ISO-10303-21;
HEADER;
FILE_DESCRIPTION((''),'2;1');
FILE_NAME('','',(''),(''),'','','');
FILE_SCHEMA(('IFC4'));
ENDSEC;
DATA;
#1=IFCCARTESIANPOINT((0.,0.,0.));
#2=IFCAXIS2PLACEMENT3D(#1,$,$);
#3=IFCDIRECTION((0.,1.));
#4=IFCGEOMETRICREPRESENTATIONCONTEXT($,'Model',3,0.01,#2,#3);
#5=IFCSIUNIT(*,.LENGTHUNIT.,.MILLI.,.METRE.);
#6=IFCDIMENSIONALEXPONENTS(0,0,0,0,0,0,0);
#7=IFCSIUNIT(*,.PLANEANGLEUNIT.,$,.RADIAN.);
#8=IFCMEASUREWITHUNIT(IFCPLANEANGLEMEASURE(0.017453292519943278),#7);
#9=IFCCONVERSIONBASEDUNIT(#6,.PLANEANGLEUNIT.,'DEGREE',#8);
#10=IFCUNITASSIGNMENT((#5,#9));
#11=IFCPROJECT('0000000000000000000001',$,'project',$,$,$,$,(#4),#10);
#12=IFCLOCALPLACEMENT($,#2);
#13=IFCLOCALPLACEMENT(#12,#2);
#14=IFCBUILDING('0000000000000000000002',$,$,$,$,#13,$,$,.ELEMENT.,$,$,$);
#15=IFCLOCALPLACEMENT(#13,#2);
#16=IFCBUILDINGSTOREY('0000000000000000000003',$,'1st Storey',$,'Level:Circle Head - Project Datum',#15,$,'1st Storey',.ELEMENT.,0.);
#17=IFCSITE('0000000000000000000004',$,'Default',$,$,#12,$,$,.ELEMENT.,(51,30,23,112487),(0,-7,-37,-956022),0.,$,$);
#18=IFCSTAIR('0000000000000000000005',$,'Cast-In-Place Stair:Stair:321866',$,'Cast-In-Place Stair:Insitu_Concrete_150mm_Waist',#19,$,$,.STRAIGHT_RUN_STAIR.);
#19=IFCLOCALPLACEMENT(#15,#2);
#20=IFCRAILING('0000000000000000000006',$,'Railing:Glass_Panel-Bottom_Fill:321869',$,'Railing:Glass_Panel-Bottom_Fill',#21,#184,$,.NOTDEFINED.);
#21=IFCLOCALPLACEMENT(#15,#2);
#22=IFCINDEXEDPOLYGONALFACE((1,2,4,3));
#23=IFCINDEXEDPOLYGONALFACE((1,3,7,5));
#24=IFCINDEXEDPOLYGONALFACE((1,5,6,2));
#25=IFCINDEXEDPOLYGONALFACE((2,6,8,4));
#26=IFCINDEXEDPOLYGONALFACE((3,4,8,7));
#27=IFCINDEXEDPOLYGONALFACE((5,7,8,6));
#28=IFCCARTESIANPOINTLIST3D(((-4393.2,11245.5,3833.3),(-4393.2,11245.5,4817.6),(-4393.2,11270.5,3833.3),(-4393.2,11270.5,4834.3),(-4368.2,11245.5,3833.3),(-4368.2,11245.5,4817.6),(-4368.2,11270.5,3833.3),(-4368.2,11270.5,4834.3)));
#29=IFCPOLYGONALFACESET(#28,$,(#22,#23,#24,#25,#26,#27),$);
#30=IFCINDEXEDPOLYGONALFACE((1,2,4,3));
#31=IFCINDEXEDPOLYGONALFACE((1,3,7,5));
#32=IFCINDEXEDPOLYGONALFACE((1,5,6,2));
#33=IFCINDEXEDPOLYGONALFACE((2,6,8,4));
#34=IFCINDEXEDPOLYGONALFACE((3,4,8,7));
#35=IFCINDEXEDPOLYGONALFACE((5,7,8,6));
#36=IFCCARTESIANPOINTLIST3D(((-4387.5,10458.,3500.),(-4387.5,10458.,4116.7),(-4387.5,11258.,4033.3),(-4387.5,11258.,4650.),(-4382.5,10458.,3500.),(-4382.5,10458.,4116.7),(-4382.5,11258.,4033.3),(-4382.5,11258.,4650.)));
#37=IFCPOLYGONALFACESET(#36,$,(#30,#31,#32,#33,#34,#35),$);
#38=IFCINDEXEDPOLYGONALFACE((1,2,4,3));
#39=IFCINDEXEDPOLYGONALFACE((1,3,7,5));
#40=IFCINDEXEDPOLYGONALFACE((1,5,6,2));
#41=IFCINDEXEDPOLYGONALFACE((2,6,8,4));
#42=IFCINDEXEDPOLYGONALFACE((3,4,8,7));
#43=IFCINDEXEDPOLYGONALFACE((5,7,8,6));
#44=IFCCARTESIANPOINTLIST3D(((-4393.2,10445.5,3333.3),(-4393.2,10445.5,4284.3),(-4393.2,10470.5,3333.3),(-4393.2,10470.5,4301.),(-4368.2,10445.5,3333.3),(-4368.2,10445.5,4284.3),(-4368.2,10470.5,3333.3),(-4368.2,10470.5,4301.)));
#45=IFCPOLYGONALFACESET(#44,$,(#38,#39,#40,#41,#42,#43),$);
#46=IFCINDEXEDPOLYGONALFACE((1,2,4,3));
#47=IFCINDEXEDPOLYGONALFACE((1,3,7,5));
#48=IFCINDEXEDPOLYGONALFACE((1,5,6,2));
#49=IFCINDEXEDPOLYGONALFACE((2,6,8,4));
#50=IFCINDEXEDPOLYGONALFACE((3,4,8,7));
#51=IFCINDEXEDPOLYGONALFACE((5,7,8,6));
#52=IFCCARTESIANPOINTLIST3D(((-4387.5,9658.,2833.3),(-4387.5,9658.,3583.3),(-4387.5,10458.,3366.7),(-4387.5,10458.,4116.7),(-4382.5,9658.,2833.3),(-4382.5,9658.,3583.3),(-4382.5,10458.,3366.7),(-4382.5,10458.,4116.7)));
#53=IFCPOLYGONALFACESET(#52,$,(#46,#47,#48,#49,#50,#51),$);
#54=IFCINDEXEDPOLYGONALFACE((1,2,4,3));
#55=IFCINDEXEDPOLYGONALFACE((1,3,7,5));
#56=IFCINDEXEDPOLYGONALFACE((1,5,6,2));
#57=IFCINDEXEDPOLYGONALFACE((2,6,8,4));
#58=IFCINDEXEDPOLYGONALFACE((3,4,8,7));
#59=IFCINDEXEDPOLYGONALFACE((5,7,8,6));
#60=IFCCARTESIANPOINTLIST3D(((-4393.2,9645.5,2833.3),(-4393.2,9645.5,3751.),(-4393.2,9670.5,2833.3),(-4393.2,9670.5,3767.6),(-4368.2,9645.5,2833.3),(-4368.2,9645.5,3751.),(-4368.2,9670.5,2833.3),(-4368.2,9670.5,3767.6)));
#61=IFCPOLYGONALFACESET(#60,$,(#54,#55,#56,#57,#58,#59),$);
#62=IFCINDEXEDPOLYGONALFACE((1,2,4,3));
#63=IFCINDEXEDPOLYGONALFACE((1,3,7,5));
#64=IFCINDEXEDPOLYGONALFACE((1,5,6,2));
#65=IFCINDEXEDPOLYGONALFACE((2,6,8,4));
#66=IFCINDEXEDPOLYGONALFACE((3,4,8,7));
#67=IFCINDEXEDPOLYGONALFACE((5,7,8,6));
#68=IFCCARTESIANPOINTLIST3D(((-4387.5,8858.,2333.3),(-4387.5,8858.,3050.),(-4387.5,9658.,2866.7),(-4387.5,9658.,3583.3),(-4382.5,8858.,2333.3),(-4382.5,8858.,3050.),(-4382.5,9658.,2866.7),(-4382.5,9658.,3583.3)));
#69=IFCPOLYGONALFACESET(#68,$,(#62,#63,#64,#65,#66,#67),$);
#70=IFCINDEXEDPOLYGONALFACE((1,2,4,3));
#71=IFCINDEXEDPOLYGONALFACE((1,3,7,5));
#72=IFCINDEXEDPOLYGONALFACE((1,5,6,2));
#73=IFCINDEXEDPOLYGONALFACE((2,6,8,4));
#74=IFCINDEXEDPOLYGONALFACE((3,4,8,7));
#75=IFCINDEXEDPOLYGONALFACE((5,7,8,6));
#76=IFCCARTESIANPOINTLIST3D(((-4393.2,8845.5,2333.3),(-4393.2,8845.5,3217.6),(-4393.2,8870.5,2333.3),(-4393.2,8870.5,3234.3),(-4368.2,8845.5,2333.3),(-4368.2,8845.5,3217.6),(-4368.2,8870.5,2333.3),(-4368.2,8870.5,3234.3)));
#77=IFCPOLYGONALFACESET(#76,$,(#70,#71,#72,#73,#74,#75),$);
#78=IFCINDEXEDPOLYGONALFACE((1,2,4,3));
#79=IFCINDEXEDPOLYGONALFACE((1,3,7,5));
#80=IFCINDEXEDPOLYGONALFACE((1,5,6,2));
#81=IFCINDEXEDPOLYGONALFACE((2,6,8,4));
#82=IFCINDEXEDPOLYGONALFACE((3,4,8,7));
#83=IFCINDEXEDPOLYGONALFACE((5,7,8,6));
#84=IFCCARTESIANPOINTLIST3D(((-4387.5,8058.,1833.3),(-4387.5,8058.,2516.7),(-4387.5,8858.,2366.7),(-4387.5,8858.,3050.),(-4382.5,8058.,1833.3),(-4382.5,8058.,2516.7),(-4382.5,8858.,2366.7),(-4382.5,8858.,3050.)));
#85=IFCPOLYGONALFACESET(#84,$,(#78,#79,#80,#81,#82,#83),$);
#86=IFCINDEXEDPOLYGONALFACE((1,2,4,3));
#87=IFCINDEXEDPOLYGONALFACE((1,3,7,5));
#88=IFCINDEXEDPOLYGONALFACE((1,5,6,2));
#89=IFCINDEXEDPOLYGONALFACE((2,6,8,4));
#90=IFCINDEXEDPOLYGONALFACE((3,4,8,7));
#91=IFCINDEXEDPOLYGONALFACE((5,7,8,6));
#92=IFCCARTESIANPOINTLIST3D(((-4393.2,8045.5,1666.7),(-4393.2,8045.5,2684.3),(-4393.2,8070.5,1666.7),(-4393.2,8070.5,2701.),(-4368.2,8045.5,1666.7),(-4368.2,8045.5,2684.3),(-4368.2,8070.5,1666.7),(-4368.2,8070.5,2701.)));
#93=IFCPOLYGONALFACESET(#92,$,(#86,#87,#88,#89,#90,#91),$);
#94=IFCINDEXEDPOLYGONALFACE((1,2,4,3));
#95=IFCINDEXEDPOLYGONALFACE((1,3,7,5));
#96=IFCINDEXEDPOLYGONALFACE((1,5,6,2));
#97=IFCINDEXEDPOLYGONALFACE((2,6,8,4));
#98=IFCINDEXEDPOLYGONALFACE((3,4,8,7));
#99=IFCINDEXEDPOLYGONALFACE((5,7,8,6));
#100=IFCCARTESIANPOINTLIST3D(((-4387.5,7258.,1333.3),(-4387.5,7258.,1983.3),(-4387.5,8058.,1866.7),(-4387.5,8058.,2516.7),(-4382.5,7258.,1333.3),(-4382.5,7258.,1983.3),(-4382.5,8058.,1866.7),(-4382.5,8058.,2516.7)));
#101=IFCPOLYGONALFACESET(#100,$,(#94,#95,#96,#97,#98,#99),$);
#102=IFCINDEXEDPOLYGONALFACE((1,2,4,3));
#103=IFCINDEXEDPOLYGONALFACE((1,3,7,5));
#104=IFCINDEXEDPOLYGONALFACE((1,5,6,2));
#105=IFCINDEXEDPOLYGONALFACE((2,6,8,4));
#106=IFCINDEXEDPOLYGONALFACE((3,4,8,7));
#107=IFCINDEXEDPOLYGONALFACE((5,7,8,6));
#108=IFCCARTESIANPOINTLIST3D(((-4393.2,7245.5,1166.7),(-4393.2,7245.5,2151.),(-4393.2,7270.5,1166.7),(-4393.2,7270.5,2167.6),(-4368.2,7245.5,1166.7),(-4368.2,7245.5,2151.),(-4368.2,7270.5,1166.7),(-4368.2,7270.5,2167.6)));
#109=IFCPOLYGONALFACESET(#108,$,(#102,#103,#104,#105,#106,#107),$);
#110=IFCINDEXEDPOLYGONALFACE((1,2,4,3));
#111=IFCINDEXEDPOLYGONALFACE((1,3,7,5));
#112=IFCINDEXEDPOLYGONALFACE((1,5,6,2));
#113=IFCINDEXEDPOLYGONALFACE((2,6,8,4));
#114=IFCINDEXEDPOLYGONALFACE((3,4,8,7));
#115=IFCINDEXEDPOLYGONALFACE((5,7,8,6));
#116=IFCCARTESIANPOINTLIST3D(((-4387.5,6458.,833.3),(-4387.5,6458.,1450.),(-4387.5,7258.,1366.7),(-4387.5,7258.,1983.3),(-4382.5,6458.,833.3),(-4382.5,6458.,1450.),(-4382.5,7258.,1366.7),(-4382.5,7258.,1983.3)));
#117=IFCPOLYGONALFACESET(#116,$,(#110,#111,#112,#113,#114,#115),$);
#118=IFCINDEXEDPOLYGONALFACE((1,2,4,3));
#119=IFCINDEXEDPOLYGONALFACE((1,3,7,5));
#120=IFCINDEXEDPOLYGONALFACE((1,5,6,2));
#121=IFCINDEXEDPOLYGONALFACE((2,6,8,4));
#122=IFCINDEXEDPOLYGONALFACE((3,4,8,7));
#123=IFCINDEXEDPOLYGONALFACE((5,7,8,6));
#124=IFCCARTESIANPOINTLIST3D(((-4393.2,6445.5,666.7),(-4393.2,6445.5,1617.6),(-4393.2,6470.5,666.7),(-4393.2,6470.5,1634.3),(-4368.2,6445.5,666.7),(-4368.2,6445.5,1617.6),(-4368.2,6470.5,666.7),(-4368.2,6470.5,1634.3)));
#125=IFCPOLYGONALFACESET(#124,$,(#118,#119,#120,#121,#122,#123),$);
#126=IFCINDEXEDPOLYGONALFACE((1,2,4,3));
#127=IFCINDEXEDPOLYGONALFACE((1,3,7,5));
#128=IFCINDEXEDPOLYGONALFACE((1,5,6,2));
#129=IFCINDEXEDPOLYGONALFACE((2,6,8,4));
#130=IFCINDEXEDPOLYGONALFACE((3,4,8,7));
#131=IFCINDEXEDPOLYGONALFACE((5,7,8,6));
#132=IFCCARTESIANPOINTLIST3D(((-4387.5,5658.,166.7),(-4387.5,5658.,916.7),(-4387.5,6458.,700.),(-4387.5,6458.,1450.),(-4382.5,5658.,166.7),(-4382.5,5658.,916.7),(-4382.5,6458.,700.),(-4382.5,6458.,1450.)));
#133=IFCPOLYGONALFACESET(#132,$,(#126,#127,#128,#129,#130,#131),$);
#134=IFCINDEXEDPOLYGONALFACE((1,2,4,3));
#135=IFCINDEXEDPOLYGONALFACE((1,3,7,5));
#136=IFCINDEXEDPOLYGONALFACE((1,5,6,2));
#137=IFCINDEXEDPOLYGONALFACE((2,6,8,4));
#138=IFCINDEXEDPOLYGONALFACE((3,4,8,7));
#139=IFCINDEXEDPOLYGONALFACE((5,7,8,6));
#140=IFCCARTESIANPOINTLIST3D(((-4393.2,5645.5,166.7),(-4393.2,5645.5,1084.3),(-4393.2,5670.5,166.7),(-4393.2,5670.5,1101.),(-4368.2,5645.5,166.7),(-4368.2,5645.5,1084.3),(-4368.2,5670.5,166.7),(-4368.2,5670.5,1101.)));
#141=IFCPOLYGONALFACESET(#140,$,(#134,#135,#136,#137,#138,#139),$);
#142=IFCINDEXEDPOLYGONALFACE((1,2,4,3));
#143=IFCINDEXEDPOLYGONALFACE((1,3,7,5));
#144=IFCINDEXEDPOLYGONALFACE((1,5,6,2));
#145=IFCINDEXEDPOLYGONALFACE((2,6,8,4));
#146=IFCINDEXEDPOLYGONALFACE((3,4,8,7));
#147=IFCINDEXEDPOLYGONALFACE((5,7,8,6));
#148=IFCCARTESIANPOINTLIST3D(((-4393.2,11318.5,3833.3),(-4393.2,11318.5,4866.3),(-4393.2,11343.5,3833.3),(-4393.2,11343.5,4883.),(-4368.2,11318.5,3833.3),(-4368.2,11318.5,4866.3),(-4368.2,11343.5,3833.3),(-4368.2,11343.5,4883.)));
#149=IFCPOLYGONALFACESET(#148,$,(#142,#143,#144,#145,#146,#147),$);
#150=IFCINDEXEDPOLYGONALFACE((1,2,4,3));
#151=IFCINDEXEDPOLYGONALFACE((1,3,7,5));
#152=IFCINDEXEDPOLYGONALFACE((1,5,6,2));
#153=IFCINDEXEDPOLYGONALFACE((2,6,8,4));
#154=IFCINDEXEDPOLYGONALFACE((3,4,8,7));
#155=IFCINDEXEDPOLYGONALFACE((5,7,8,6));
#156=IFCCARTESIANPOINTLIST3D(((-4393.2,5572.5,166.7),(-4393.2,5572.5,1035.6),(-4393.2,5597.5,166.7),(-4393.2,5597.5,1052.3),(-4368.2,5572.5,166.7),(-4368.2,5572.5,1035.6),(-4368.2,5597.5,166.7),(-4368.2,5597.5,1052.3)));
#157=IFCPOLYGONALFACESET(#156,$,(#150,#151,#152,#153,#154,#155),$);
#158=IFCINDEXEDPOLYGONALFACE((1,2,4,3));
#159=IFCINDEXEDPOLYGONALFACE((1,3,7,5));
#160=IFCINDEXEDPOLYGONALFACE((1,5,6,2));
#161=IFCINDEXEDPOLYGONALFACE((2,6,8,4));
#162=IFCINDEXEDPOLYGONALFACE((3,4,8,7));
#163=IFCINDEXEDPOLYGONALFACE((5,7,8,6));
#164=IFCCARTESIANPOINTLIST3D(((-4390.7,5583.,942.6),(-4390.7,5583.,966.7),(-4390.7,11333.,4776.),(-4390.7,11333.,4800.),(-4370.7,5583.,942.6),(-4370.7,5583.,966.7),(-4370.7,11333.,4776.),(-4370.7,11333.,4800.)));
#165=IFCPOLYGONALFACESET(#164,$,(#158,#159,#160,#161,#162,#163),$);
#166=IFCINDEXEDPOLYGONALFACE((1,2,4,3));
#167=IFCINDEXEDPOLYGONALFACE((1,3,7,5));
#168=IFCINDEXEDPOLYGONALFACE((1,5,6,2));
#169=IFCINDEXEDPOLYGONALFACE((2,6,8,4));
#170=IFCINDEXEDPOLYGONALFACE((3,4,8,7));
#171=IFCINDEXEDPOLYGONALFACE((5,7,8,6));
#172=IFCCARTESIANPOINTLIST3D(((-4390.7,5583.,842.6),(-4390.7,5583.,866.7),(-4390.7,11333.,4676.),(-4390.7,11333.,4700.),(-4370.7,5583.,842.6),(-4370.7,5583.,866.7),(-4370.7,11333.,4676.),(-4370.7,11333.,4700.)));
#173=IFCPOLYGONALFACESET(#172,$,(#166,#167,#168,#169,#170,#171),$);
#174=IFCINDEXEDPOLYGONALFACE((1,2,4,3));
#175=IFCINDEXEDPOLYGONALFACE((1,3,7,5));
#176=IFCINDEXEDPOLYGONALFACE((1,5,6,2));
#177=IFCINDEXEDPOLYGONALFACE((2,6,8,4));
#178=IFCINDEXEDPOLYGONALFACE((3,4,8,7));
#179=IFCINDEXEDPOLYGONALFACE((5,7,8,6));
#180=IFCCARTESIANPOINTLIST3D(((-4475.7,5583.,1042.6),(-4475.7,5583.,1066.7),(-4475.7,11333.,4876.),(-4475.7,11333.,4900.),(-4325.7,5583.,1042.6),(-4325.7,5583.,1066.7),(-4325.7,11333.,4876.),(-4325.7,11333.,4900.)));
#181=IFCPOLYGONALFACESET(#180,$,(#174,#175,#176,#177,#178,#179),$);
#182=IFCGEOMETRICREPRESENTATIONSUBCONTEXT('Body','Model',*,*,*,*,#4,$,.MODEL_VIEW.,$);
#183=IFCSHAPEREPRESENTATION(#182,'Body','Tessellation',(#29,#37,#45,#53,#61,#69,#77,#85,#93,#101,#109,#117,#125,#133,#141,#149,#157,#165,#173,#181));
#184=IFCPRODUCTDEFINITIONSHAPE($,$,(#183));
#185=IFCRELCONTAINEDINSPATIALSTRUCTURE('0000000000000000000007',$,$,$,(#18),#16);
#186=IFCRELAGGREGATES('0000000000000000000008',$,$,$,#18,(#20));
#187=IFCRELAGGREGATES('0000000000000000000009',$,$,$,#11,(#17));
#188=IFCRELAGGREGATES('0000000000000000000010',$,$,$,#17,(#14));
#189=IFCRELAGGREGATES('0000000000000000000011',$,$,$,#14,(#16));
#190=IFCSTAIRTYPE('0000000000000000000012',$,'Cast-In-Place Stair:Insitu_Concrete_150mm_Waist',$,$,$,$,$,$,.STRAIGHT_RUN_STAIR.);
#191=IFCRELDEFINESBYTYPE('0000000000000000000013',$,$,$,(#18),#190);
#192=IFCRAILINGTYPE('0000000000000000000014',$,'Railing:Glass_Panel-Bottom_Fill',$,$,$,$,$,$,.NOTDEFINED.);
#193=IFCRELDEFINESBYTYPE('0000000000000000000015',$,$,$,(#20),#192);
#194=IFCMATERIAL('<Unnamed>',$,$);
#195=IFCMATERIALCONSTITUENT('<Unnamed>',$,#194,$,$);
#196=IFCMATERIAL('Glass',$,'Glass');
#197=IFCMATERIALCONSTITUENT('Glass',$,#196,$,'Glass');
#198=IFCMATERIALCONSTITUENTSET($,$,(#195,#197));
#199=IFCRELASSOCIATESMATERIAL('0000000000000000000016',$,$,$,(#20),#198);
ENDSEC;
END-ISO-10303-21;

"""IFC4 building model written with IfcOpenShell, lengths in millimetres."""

from ifc_helpers import new_model, entity, si_unit, converted_unit, direction, frame, origin, place, context, subcontext, project, spatial, indexed_curve, outline, extrude, material, constituent, constituent_set, type_object, element, aggregate, save


model = new_model("IFC4")

# Units and contexts
model_context = context("Model", 3, precision=0.01, world=origin(), true_north=direction((0.0, 1.0)))
body_context = subcontext(model_context, "Body", "Model", "MODEL_VIEW")
ifc_project = project(units=[si_unit("LENGTHUNIT", "METRE", prefix="MILLI"), converted_unit("PLANEANGLEUNIT", "DEGREE", entity("IfcPlaneAngleMeasure", 0.017453292519943278), si_unit("PLANEANGLEUNIT", "RADIAN"), dimensions=[0, 0, 0, 0, 0, 0, 0])], contexts=[model_context])

# Site, building, storey
site_placement = place(None, origin())
site = spatial("IfcSite", under=ifc_project, at=site_placement, Name="Default", CompositionType="ELEMENT", RefLatitude=(51, 30, 23, 112487), RefLongitude=(0, -7, -37, -956022), RefElevation=0.0)
building_placement = place(site_placement, origin())
building = spatial("IfcBuilding", under=site, at=building_placement, CompositionType="ELEMENT")
storey_placement = place(building_placement, origin())
storey = spatial("IfcBuildingStorey", under=building, at=storey_placement, Name="1st Storey", ObjectType="Level:Circle Head - Project Datum", LongName="1st Storey", CompositionType="ELEMENT", Elevation=0.0)

# Shared definitions
ifc_material_1 = material(Name="<Unnamed>")

# Shared definitions
stair_type_1 = type_object("IfcStairType", Name="Cast-In-Place Stair:Insitu_Concrete_150mm_Waist", PredefinedType="STRAIGHT_RUN_STAIR")

# Stair, railing
ifc_material_2 = material(Name="Glass", Category="Glass")
railing_type_1 = type_object("IfcRailingType", Name="Railing:Glass_Panel-Bottom_Fill", PredefinedType="NOTDEFINED")
stair_1_placement = place(storey_placement, origin())
stair_1 = element("IfcStair", 1, at=stair_1_placement, inside=storey, type_object=stair_type_1, Name="Cast-In-Place Stair:Stair:321866", ObjectType="Cast-In-Place Stair:Insitu_Concrete_150mm_Waist", PredefinedType="STRAIGHT_RUN_STAIR")
ifc_constituent_1 = constituent(ifc_material_1, Name="<Unnamed>")
ifc_constituent_2 = constituent(ifc_material_2, Name="Glass", Category="Glass")
ifc_constituent_set_1 = constituent_set(constituents=[ifc_constituent_1, ifc_constituent_2])
railing_1_placement = place(stair_1_placement, frame((-4475.7, 5572.5, 166.7)))
railing_1 = element("IfcRailing", 2, at=railing_1_placement, type_object=railing_type_1, material=ifc_constituent_set_1, Name="Railing:Glass_Panel-Bottom_Fill:321869", ObjectType="Railing:Glass_Panel-Bottom_Fill", PredefinedType="NOTDEFINED", context=body_context, shape_type="SweptSolid", body=[
    extrude(outline(indexed_curve([(-488.0, -12.5), (496.3, -12.5), (496.3, 12.5), (-504.6, 12.5), (-488.0, -12.5)], self_intersect=False)), frame((82.5, 5685.5, 4163.0), z_axis=(1.0, 0.0, 0.0), x_axis=(0.0, 0.0, -1.0)), (0.0, 0.0, 1.0), 25.0),
    extrude(outline(indexed_curve([(-41.7, -400.0), (575.0, -400.0), (41.7, 400.0), (-575.0, 400.0), (-41.7, -400.0)], self_intersect=False)), frame((88.3, 5285.5, 3908.3), z_axis=(1.0, 0.0, 0.0), x_axis=(0.0, 0.0, -1.0)), (0.0, 0.0, 1.0), 5.0),
    extrude(outline(indexed_curve([(-471.3, -12.5), (479.6, -12.5), (479.6, 12.5), (-488.0, 12.5), (-471.3, -12.5)], self_intersect=False)), frame((82.5, 4885.5, 3646.3), z_axis=(1.0, 0.0, 0.0), x_axis=(0.0, 0.0, -1.0)), (0.0, 0.0, 1.0), 25.0),
    extrude(outline(indexed_curve([(-108.3, -400.0), (641.7, -400.0), (108.3, 400.0), (-641.7, 400.0), (-108.3, -400.0)], self_intersect=False)), frame((88.3, 4485.5, 3308.3), z_axis=(1.0, 0.0, 0.0), x_axis=(0.0, 0.0, -1.0)), (0.0, 0.0, 1.0), 5.0),
    extrude(outline(indexed_curve([(-454.6, -12.5), (463.0, -12.5), (463.0, 12.5), (-471.3, 12.5), (-454.6, -12.5)], self_intersect=False)), frame((82.5, 4085.5, 3129.6), z_axis=(1.0, 0.0, 0.0), x_axis=(0.0, 0.0, -1.0)), (0.0, 0.0, 1.0), 25.0),
    extrude(outline(indexed_curve([(-91.7, -400.0), (625.0, -400.0), (91.7, 400.0), (-625.0, 400.0), (-91.7, -400.0)], self_intersect=False)), frame((88.3, 3685.5, 2791.7), z_axis=(1.0, 0.0, 0.0), x_axis=(0.0, 0.0, -1.0)), (0.0, 0.0, 1.0), 5.0),
    extrude(outline(indexed_curve([(-438.0, -12.5), (446.3, -12.5), (446.3, 12.5), (-454.6, 12.5), (-438.0, -12.5)], self_intersect=False)), frame((82.5, 3285.5, 2613.0), z_axis=(1.0, 0.0, 0.0), x_axis=(0.0, 0.0, -1.0)), (0.0, 0.0, 1.0), 25.0),
    extrude(outline(indexed_curve([(-75.0, -400.0), (608.3, -400.0), (75.0, 400.0), (-608.3, 400.0), (-75.0, -400.0)], self_intersect=False)), frame((88.3, 2885.5, 2275.0), z_axis=(1.0, 0.0, 0.0), x_axis=(0.0, 0.0, -1.0)), (0.0, 0.0, 1.0), 5.0),
    extrude(outline(indexed_curve([(-504.6, -12.5), (513.0, -12.5), (513.0, 12.5), (-521.3, 12.5), (-504.6, -12.5)], self_intersect=False)), frame((82.5, 2485.5, 2013.0), z_axis=(1.0, 0.0, 0.0), x_axis=(0.0, 0.0, -1.0)), (0.0, 0.0, 1.0), 25.0),
    extrude(outline(indexed_curve([(-58.3, -400.0), (591.7, -400.0), (58.3, 400.0), (-591.7, 400.0), (-58.3, -400.0)], self_intersect=False)), frame((88.3, 2085.5, 1758.3), z_axis=(1.0, 0.0, 0.0), x_axis=(0.0, 0.0, -1.0)), (0.0, 0.0, 1.0), 5.0),
    extrude(outline(indexed_curve([(-488.0, -12.5), (496.3, -12.5), (496.3, 12.5), (-504.6, 12.5), (-488.0, -12.5)], self_intersect=False)), frame((82.5, 1685.5, 1496.3), z_axis=(1.0, 0.0, 0.0), x_axis=(0.0, 0.0, -1.0)), (0.0, 0.0, 1.0), 25.0),
    extrude(outline(indexed_curve([(-41.7, -400.0), (575.0, -400.0), (41.7, 400.0), (-575.0, 400.0), (-41.7, -400.0)], self_intersect=False)), frame((88.3, 1285.5, 1241.7), z_axis=(1.0, 0.0, 0.0), x_axis=(0.0, 0.0, -1.0)), (0.0, 0.0, 1.0), 5.0),
    extrude(outline(indexed_curve([(-471.3, -12.5), (479.6, -12.5), (479.6, 12.5), (-488.0, 12.5), (-471.3, -12.5)], self_intersect=False)), frame((82.5, 885.5, 979.6), z_axis=(1.0, 0.0, 0.0), x_axis=(0.0, 0.0, -1.0)), (0.0, 0.0, 1.0), 25.0),
    extrude(outline(indexed_curve([(-108.3, -400.0), (641.7, -400.0), (108.3, 400.0), (-641.7, 400.0), (-108.3, -400.0)], self_intersect=False)), frame((88.3, 485.5, 641.7), z_axis=(1.0, 0.0, 0.0), x_axis=(0.0, 0.0, -1.0)), (0.0, 0.0, 1.0), 5.0),
    extrude(outline(indexed_curve([(-454.6, -12.5), (463.0, -12.5), (463.0, 12.5), (-471.3, 12.5), (-454.6, -12.5)], self_intersect=False)), frame((82.5, 85.5, 463.0), z_axis=(1.0, 0.0, 0.0), x_axis=(0.0, 0.0, -1.0)), (0.0, 0.0, 1.0), 25.0),
    extrude(outline(indexed_curve([(-512.3, -12.5), (520.6, -12.5), (520.6, 12.5), (-529.0, 12.5), (-512.3, -12.5)], self_intersect=False)), frame((82.5, 5758.5, 4187.3), z_axis=(1.0, 0.0, 0.0), x_axis=(0.0, 0.0, -1.0)), (0.0, 0.0, 1.0), 25.0),
    extrude(outline(indexed_curve([(-430.3, -12.5), (438.6, -12.5), (438.6, 12.5), (-447.0, 12.5), (-430.3, -12.5)], self_intersect=False)), frame((82.5, 12.5, 438.6), z_axis=(1.0, 0.0, 0.0), x_axis=(0.0, 0.0, -1.0)), (0.0, 0.0, 1.0), 25.0),
    extrude(outline(indexed_curve([(-3462.0, -10.0), (3448.7, -10.0), (3462.0, 10.0), (-3448.7, 10.0), (-3462.0, -10.0)], self_intersect=False)), frame((85.0, 2885.5, 2704.6), z_axis=(1.0, 0.0, 0.0), x_axis=(0.0, 0.83205, 0.5547)), (0.0, 0.0, 1.0), 20.0),
    extrude(outline(indexed_curve([(-3462.0, -10.0), (3448.7, -10.0), (3462.0, 10.0), (-3448.7, 10.0), (-3462.0, -10.0)], self_intersect=False)), frame((85.0, 2885.5, 2604.6), z_axis=(1.0, 0.0, 0.0), x_axis=(0.0, 0.83205, 0.5547)), (0.0, 0.0, 1.0), 20.0),
    extrude(outline(indexed_curve([(-3462.0, -10.0), (3448.7, -10.0), (3462.0, 10.0), (-3448.7, 10.0), (-3462.0, -10.0)], self_intersect=False)), frame((0.0, 2885.5, 2804.6), z_axis=(1.0, 0.0, 0.0), x_axis=(0.0, 0.83205, 0.5547)), (0.0, 0.0, 1.0), 150.0),
])
aggregate(stair_1, [railing_1])

save(model, "model.ifc")
